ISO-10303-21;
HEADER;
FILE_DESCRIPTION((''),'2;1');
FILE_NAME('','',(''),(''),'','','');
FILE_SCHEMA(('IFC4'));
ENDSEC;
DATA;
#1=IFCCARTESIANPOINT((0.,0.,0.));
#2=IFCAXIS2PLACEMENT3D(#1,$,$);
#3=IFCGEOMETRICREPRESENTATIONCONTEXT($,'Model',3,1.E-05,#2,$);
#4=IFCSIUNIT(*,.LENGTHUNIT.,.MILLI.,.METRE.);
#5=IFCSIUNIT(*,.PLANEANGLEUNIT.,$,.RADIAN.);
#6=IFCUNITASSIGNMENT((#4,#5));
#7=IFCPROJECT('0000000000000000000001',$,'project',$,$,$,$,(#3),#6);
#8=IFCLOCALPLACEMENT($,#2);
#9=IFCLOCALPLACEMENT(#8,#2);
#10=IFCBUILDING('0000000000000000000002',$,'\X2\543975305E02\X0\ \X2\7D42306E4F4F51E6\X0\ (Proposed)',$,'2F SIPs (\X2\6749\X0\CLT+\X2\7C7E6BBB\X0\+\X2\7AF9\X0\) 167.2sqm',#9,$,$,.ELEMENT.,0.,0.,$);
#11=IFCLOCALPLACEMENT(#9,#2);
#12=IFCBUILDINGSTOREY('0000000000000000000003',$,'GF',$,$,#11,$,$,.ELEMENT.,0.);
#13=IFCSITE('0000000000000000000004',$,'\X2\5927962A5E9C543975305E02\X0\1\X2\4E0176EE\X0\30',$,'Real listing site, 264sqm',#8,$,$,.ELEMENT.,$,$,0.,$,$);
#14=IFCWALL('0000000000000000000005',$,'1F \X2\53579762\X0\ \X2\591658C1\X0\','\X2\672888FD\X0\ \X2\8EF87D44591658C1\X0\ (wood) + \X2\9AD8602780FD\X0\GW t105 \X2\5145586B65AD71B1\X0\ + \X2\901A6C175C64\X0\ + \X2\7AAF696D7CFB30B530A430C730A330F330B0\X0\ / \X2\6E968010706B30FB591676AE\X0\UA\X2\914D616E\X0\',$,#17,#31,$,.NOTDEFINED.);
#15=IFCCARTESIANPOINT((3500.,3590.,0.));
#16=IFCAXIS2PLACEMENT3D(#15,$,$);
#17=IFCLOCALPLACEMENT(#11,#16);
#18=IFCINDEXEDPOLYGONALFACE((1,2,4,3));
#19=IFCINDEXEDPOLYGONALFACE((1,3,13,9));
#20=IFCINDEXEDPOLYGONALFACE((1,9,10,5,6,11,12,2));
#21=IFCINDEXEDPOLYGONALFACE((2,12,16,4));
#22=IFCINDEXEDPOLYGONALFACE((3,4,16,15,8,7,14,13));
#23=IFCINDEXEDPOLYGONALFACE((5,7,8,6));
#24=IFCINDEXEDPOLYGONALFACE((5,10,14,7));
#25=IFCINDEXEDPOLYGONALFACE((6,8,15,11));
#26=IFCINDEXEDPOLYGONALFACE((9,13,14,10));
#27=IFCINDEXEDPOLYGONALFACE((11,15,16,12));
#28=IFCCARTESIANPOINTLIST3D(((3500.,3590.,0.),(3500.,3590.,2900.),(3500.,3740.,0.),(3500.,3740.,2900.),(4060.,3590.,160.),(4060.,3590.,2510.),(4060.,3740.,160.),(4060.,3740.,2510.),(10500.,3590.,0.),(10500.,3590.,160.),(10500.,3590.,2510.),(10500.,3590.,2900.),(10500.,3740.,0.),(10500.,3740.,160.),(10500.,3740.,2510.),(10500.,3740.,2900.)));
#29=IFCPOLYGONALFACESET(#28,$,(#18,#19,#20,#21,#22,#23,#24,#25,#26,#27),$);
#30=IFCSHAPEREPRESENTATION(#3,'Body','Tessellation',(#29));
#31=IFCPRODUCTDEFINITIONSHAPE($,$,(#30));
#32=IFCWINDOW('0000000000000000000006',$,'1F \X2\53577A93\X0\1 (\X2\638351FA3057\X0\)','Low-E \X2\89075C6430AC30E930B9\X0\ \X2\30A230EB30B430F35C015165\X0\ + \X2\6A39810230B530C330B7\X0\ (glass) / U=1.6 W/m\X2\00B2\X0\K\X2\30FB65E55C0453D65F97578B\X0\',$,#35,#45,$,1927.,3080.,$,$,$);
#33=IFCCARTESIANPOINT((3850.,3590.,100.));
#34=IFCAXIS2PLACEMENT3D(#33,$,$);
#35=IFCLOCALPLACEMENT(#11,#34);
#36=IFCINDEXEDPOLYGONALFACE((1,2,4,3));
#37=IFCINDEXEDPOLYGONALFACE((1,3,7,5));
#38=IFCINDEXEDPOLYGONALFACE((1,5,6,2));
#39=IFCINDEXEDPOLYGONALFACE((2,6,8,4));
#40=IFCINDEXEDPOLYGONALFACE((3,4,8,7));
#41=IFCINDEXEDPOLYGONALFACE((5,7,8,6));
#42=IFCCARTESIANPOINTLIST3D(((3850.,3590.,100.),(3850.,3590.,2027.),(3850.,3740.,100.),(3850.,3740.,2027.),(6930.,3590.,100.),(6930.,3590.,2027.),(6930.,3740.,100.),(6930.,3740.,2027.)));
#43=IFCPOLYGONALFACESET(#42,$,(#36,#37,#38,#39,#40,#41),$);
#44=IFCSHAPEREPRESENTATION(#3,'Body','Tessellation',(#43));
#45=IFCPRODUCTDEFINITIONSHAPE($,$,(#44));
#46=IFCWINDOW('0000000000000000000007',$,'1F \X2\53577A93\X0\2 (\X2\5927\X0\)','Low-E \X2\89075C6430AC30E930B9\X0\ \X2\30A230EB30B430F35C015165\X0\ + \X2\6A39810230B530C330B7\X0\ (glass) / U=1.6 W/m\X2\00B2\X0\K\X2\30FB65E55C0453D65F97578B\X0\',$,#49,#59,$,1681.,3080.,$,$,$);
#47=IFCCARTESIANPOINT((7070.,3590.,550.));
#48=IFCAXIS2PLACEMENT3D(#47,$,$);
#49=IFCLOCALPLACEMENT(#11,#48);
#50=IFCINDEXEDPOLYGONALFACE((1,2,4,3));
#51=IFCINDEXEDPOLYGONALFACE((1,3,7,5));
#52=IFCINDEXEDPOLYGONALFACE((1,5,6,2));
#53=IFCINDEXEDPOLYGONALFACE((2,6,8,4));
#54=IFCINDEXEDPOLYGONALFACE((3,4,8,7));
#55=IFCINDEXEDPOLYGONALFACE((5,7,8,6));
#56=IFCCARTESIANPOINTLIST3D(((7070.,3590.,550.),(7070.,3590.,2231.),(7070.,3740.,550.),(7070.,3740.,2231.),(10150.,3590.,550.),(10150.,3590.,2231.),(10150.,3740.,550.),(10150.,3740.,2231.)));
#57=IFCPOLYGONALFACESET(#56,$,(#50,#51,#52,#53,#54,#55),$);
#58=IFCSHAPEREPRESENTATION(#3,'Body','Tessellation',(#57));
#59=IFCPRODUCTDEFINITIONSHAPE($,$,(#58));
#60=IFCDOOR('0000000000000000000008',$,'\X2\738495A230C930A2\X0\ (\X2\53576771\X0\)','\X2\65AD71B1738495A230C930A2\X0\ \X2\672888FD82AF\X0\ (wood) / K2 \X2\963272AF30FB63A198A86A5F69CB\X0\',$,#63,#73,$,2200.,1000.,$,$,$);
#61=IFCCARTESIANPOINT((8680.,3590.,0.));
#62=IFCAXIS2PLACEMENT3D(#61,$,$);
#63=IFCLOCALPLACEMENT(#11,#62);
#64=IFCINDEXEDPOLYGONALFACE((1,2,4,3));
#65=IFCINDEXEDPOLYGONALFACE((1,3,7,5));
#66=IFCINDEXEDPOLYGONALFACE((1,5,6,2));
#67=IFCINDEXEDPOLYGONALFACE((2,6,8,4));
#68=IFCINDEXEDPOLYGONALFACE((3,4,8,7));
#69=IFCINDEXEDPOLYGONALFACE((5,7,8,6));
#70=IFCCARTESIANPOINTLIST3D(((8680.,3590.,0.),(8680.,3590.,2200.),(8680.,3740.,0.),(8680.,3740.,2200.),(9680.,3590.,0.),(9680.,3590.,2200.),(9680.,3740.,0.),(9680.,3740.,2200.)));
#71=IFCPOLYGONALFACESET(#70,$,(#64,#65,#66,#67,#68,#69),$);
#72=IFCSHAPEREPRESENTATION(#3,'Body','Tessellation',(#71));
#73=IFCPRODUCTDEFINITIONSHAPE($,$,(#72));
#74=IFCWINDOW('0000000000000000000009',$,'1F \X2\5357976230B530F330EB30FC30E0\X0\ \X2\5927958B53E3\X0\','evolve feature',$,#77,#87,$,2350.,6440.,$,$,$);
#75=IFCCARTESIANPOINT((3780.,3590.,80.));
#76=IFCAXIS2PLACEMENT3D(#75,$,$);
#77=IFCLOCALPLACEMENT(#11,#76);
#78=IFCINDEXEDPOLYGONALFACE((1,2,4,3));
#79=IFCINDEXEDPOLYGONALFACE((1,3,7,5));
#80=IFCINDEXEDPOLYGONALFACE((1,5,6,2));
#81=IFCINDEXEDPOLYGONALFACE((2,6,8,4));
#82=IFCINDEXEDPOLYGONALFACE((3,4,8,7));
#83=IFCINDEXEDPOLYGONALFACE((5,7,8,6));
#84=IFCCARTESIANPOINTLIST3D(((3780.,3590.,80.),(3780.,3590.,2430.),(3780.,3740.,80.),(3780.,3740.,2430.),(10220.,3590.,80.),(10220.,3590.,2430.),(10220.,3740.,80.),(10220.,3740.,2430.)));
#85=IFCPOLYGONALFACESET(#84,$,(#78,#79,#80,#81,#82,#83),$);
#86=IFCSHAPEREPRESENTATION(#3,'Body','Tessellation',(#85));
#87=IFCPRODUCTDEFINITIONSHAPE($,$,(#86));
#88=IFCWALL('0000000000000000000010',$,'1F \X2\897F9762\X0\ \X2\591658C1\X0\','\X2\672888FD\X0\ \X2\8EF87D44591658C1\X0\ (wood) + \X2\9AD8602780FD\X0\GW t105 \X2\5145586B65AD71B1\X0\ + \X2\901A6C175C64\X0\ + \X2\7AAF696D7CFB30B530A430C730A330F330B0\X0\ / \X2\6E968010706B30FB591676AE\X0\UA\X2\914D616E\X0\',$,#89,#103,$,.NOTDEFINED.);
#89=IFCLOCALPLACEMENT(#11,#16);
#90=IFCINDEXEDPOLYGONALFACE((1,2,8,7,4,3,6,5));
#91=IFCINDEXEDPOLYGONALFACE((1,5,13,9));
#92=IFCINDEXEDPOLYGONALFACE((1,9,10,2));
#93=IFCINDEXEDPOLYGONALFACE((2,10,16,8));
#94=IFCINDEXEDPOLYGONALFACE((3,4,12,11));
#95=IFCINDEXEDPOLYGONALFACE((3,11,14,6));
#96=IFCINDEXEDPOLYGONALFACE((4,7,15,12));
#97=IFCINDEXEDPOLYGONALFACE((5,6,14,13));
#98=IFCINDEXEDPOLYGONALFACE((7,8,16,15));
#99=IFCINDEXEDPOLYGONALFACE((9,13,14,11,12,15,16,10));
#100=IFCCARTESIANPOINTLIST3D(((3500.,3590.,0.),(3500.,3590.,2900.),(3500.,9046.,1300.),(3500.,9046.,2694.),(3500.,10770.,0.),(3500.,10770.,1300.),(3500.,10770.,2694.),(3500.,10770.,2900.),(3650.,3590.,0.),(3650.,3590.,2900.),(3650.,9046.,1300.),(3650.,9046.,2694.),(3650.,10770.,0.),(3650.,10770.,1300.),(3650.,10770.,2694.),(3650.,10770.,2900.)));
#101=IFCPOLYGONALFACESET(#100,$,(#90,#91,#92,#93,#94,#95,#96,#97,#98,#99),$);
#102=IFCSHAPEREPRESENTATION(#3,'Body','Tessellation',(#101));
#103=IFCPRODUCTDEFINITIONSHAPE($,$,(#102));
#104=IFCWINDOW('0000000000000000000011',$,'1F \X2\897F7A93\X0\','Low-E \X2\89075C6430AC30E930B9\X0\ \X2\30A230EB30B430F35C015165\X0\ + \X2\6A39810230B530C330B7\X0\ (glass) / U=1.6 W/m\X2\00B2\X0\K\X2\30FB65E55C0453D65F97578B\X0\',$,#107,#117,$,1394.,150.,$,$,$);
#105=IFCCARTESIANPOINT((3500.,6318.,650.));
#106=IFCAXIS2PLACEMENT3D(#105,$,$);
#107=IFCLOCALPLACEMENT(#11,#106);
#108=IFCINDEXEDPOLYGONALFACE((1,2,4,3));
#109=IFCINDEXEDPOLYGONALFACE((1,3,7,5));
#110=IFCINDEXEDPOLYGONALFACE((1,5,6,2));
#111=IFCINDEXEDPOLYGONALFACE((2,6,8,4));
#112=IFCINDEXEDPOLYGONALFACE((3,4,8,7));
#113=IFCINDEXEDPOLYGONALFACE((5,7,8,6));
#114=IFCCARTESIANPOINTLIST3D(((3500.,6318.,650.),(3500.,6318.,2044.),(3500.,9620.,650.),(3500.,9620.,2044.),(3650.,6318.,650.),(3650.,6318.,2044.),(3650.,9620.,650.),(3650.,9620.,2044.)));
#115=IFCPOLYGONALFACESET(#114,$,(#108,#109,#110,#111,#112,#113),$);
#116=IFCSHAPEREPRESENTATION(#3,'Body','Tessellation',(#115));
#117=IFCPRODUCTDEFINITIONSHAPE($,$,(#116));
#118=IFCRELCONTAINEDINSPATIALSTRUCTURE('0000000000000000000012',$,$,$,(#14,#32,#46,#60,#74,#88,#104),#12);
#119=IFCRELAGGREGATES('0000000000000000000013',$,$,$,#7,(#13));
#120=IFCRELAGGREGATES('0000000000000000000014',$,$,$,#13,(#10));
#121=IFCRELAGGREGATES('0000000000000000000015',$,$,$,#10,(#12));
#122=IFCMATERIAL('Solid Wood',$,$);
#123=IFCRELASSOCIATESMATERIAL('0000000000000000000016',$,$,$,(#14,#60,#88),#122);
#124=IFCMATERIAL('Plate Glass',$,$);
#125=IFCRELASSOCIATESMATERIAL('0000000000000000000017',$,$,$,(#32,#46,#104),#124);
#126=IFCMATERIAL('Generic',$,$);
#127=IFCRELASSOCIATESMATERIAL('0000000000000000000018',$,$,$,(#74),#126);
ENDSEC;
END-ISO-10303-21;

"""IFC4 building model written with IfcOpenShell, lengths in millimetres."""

from ifc_helpers import new_model, si_unit, frame, frame_2d, origin, place, context, project, spatial, rectangle, extrude, material, element, fill, save


model = new_model("IFC4")

# Units and contexts
model_context = context("Model", 3, precision=1e-05, world=origin())
ifc_project = project(units=[si_unit("LENGTHUNIT", "METRE", prefix="MILLI"), si_unit("PLANEANGLEUNIT", "RADIAN")], contexts=[model_context])

# Site, building, storey
site_placement = place(None, origin())
site = spatial("IfcSite", under=ifc_project, at=site_placement, Name="大阪府吹田市1丁目30", ObjectType="Real listing site, 264sqm", CompositionType="ELEMENT", RefElevation=0.0)
building_placement = place(site_placement, origin())
building = spatial("IfcBuilding", under=site, at=building_placement, Name="吹田市 終の住処 (Proposed)", ObjectType="2F SIPs (杉CLT+籾殻+竹) 167.2sqm", CompositionType="ELEMENT", ElevationOfRefHeight=0.0, ElevationOfTerrain=0.0)
storey_placement = place(building_placement, origin())
storey = spatial("IfcBuildingStorey", under=building, at=storey_placement, Name="GF", CompositionType="ELEMENT", Elevation=0.0)

# Shared definitions
ifc_material_1 = material(Name="Solid Wood")
ifc_material_2 = material(Name="Generic")

# Wall, openings, windows, door
wall_1_placement = place(storey_placement, frame((3500.0, 3590.0, 0.0)))
wall_1 = element("IfcWall", 1, at=wall_1_placement, inside=storey, material=ifc_material_1, Name="1F 南面 外壁", Description="木製 軸組外壁 (wood) + 高性能GW t105 充填断熱 + 通気層 + 窯業系サイディング / 準耐火・外皮UA配慮", PredefinedType="NOTDEFINED", context=model_context, shape_type="SweptSolid", body=[
    extrude(rectangle(XDim=7000.0, YDim=150.0, at=frame_2d((3500.0, 75.0))), frame((3500.0, 3590.0, 0.0)), (0.0, 0.0, 1.0), 2900.0),
])
opening_1_placement = place(storey_placement, frame((3850.0, 3590.0, 100.0)))
opening_1 = element("IfcOpeningElement", 2, at=opening_1_placement, cuts=wall_1, PredefinedType="NOTDEFINED", context=model_context, shape_type="SweptSolid", body=[
    extrude(rectangle(XDim=3080.0, YDim=150.0, at=frame_2d((1540.0, 75.0))), frame((3850.0, 3590.0, 100.0)), (0.0, 0.0, 1.0), 1927.0),
])
opening_2_placement = place(storey_placement, frame((7070.0, 3590.0, 550.0)))
opening_2 = element("IfcOpeningElement", 3, at=opening_2_placement, cuts=wall_1, PredefinedType="NOTDEFINED", context=model_context, shape_type="SweptSolid", body=[
    extrude(rectangle(XDim=3080.0, YDim=150.0, at=frame_2d((1540.0, 75.0))), frame((7070.0, 3590.0, 550.0)), (0.0, 0.0, 1.0), 1681.0),
])
opening_3_placement = place(storey_placement, frame((8680.0, 3590.0, 0.0)))
opening_3 = element("IfcOpeningElement", 4, at=opening_3_placement, cuts=wall_1, PredefinedType="NOTDEFINED", context=model_context, shape_type="SweptSolid", body=[
    extrude(rectangle(XDim=1000.0, YDim=150.0, at=frame_2d((500.0, 75.0))), frame((8680.0, 3590.0, 0.0)), (0.0, 0.0, 1.0), 2200.0),
])
opening_4_placement = place(storey_placement, frame((3780.0, 3590.0, 80.0)))
opening_4 = element("IfcOpeningElement", 5, at=opening_4_placement, cuts=wall_1, PredefinedType="NOTDEFINED", context=model_context, shape_type="SweptSolid", body=[
    extrude(rectangle(XDim=6440.0, YDim=150.0, at=frame_2d((3220.0, 75.0))), frame((3780.0, 3590.0, 80.0)), (0.0, 0.0, 1.0), 2350.0),
])
ifc_material_3 = material(Name="Plate Glass")
window_1_placement = place(storey_placement, frame((3850.0, 3590.0, 100.0)))
window_1 = element("IfcWindow", 6, at=window_1_placement, inside=storey, material=ifc_material_3, Name="1F 南窓1 (掃出し)", Description="Low-E 複層ガラス アルゴン封入 + 樹脂サッシ (glass) / U=1.6 W/m²K・日射取得型", OverallHeight=1927.0, OverallWidth=3080.0, context=model_context, shape_type="SweptSolid", body=[
    extrude(rectangle(XDim=3080.0, YDim=150.0, at=frame_2d((1540.0, 75.0))), frame((3850.0, 3590.0, 100.0)), (0.0, 0.0, 1.0), 1927.0),
])
fill(opening_1, window_1)
window_2_placement = place(storey_placement, frame((7070.0, 3590.0, 550.0)))
window_2 = element("IfcWindow", 7, at=window_2_placement, inside=storey, material=ifc_material_3, Name="1F 南窓2 (大)", Description="Low-E 複層ガラス アルゴン封入 + 樹脂サッシ (glass) / U=1.6 W/m²K・日射取得型", OverallHeight=1681.0, OverallWidth=3080.0, context=model_context, shape_type="SweptSolid", body=[
    extrude(rectangle(XDim=3080.0, YDim=150.0, at=frame_2d((1540.0, 75.0))), frame((7070.0, 3590.0, 550.0)), (0.0, 0.0, 1.0), 1681.0),
])
fill(opening_2, window_2)
door_placement = place(storey_placement, frame((8680.0, 3590.0, 0.0)))
door = element("IfcDoor", 8, at=door_placement, inside=storey, material=ifc_material_1, Name="玄関ドア (南東)", Description="断熱玄関ドア 木製芯 (wood) / K2 防犯・採風機構", OverallHeight=2200.0, OverallWidth=1000.0, context=model_context, shape_type="SweptSolid", body=[
    extrude(rectangle(XDim=1000.0, YDim=150.0, at=frame_2d((500.0, 75.0))), frame((8680.0, 3590.0, 0.0)), (0.0, 0.0, 1.0), 2200.0),
])
fill(opening_3, door)
window_3_placement = place(storey_placement, frame((3780.0, 3590.0, 80.0)))
window_3 = element("IfcWindow", 9, at=window_3_placement, inside=storey, material=ifc_material_2, Name="1F 南面サンルーム 大開口", Description="evolve feature", OverallHeight=2350.0, OverallWidth=6440.0, context=model_context, shape_type="SweptSolid", body=[
    extrude(rectangle(XDim=6440.0, YDim=150.0, at=frame_2d((3220.0, 75.0))), frame((3780.0, 3590.0, 80.0)), (0.0, 0.0, 1.0), 2350.0),
])
fill(opening_4, window_3)

# Wall, opening, window
wall_2_placement = place(storey_placement, frame((3500.0, 3590.0, 0.0)))
wall_2 = element("IfcWall", 10, at=wall_2_placement, inside=storey, material=ifc_material_1, Name="1F 西面 外壁", Description="木製 軸組外壁 (wood) + 高性能GW t105 充填断熱 + 通気層 + 窯業系サイディング / 準耐火・外皮UA配慮", PredefinedType="NOTDEFINED", context=model_context, shape_type="SweptSolid", body=[
    extrude(rectangle(XDim=150.0, YDim=7180.0, at=frame_2d((75.0, 3590.0))), frame((3500.0, 3590.0, 0.0)), (0.0, 0.0, 1.0), 2900.0),
])
opening_5_placement = place(storey_placement, frame((3500.0, 6318.0, 650.0)))
opening_5 = element("IfcOpeningElement", 11, at=opening_5_placement, cuts=wall_2, PredefinedType="NOTDEFINED", context=model_context, shape_type="SweptSolid", body=[
    extrude(rectangle(XDim=150.0, YDim=3302.0, at=frame_2d((75.0, 1651.0))), frame((3500.0, 6318.0, 650.0)), (0.0, 0.0, 1.0), 1394.0),
])
window_4_placement = place(storey_placement, frame((3500.0, 6318.0, 650.0)))
window_4 = element("IfcWindow", 12, at=window_4_placement, inside=storey, material=ifc_material_3, Name="1F 西窓", Description="Low-E 複層ガラス アルゴン封入 + 樹脂サッシ (glass) / U=1.6 W/m²K・日射取得型", OverallHeight=1394.0, OverallWidth=150.0, context=model_context, shape_type="SweptSolid", body=[
    extrude(rectangle(XDim=150.0, YDim=3302.0, at=frame_2d((75.0, 1651.0))), frame((3500.0, 6318.0, 650.0)), (0.0, 0.0, 1.0), 1394.0),
])
fill(opening_5, window_4)

save(model, "model.ifc")
